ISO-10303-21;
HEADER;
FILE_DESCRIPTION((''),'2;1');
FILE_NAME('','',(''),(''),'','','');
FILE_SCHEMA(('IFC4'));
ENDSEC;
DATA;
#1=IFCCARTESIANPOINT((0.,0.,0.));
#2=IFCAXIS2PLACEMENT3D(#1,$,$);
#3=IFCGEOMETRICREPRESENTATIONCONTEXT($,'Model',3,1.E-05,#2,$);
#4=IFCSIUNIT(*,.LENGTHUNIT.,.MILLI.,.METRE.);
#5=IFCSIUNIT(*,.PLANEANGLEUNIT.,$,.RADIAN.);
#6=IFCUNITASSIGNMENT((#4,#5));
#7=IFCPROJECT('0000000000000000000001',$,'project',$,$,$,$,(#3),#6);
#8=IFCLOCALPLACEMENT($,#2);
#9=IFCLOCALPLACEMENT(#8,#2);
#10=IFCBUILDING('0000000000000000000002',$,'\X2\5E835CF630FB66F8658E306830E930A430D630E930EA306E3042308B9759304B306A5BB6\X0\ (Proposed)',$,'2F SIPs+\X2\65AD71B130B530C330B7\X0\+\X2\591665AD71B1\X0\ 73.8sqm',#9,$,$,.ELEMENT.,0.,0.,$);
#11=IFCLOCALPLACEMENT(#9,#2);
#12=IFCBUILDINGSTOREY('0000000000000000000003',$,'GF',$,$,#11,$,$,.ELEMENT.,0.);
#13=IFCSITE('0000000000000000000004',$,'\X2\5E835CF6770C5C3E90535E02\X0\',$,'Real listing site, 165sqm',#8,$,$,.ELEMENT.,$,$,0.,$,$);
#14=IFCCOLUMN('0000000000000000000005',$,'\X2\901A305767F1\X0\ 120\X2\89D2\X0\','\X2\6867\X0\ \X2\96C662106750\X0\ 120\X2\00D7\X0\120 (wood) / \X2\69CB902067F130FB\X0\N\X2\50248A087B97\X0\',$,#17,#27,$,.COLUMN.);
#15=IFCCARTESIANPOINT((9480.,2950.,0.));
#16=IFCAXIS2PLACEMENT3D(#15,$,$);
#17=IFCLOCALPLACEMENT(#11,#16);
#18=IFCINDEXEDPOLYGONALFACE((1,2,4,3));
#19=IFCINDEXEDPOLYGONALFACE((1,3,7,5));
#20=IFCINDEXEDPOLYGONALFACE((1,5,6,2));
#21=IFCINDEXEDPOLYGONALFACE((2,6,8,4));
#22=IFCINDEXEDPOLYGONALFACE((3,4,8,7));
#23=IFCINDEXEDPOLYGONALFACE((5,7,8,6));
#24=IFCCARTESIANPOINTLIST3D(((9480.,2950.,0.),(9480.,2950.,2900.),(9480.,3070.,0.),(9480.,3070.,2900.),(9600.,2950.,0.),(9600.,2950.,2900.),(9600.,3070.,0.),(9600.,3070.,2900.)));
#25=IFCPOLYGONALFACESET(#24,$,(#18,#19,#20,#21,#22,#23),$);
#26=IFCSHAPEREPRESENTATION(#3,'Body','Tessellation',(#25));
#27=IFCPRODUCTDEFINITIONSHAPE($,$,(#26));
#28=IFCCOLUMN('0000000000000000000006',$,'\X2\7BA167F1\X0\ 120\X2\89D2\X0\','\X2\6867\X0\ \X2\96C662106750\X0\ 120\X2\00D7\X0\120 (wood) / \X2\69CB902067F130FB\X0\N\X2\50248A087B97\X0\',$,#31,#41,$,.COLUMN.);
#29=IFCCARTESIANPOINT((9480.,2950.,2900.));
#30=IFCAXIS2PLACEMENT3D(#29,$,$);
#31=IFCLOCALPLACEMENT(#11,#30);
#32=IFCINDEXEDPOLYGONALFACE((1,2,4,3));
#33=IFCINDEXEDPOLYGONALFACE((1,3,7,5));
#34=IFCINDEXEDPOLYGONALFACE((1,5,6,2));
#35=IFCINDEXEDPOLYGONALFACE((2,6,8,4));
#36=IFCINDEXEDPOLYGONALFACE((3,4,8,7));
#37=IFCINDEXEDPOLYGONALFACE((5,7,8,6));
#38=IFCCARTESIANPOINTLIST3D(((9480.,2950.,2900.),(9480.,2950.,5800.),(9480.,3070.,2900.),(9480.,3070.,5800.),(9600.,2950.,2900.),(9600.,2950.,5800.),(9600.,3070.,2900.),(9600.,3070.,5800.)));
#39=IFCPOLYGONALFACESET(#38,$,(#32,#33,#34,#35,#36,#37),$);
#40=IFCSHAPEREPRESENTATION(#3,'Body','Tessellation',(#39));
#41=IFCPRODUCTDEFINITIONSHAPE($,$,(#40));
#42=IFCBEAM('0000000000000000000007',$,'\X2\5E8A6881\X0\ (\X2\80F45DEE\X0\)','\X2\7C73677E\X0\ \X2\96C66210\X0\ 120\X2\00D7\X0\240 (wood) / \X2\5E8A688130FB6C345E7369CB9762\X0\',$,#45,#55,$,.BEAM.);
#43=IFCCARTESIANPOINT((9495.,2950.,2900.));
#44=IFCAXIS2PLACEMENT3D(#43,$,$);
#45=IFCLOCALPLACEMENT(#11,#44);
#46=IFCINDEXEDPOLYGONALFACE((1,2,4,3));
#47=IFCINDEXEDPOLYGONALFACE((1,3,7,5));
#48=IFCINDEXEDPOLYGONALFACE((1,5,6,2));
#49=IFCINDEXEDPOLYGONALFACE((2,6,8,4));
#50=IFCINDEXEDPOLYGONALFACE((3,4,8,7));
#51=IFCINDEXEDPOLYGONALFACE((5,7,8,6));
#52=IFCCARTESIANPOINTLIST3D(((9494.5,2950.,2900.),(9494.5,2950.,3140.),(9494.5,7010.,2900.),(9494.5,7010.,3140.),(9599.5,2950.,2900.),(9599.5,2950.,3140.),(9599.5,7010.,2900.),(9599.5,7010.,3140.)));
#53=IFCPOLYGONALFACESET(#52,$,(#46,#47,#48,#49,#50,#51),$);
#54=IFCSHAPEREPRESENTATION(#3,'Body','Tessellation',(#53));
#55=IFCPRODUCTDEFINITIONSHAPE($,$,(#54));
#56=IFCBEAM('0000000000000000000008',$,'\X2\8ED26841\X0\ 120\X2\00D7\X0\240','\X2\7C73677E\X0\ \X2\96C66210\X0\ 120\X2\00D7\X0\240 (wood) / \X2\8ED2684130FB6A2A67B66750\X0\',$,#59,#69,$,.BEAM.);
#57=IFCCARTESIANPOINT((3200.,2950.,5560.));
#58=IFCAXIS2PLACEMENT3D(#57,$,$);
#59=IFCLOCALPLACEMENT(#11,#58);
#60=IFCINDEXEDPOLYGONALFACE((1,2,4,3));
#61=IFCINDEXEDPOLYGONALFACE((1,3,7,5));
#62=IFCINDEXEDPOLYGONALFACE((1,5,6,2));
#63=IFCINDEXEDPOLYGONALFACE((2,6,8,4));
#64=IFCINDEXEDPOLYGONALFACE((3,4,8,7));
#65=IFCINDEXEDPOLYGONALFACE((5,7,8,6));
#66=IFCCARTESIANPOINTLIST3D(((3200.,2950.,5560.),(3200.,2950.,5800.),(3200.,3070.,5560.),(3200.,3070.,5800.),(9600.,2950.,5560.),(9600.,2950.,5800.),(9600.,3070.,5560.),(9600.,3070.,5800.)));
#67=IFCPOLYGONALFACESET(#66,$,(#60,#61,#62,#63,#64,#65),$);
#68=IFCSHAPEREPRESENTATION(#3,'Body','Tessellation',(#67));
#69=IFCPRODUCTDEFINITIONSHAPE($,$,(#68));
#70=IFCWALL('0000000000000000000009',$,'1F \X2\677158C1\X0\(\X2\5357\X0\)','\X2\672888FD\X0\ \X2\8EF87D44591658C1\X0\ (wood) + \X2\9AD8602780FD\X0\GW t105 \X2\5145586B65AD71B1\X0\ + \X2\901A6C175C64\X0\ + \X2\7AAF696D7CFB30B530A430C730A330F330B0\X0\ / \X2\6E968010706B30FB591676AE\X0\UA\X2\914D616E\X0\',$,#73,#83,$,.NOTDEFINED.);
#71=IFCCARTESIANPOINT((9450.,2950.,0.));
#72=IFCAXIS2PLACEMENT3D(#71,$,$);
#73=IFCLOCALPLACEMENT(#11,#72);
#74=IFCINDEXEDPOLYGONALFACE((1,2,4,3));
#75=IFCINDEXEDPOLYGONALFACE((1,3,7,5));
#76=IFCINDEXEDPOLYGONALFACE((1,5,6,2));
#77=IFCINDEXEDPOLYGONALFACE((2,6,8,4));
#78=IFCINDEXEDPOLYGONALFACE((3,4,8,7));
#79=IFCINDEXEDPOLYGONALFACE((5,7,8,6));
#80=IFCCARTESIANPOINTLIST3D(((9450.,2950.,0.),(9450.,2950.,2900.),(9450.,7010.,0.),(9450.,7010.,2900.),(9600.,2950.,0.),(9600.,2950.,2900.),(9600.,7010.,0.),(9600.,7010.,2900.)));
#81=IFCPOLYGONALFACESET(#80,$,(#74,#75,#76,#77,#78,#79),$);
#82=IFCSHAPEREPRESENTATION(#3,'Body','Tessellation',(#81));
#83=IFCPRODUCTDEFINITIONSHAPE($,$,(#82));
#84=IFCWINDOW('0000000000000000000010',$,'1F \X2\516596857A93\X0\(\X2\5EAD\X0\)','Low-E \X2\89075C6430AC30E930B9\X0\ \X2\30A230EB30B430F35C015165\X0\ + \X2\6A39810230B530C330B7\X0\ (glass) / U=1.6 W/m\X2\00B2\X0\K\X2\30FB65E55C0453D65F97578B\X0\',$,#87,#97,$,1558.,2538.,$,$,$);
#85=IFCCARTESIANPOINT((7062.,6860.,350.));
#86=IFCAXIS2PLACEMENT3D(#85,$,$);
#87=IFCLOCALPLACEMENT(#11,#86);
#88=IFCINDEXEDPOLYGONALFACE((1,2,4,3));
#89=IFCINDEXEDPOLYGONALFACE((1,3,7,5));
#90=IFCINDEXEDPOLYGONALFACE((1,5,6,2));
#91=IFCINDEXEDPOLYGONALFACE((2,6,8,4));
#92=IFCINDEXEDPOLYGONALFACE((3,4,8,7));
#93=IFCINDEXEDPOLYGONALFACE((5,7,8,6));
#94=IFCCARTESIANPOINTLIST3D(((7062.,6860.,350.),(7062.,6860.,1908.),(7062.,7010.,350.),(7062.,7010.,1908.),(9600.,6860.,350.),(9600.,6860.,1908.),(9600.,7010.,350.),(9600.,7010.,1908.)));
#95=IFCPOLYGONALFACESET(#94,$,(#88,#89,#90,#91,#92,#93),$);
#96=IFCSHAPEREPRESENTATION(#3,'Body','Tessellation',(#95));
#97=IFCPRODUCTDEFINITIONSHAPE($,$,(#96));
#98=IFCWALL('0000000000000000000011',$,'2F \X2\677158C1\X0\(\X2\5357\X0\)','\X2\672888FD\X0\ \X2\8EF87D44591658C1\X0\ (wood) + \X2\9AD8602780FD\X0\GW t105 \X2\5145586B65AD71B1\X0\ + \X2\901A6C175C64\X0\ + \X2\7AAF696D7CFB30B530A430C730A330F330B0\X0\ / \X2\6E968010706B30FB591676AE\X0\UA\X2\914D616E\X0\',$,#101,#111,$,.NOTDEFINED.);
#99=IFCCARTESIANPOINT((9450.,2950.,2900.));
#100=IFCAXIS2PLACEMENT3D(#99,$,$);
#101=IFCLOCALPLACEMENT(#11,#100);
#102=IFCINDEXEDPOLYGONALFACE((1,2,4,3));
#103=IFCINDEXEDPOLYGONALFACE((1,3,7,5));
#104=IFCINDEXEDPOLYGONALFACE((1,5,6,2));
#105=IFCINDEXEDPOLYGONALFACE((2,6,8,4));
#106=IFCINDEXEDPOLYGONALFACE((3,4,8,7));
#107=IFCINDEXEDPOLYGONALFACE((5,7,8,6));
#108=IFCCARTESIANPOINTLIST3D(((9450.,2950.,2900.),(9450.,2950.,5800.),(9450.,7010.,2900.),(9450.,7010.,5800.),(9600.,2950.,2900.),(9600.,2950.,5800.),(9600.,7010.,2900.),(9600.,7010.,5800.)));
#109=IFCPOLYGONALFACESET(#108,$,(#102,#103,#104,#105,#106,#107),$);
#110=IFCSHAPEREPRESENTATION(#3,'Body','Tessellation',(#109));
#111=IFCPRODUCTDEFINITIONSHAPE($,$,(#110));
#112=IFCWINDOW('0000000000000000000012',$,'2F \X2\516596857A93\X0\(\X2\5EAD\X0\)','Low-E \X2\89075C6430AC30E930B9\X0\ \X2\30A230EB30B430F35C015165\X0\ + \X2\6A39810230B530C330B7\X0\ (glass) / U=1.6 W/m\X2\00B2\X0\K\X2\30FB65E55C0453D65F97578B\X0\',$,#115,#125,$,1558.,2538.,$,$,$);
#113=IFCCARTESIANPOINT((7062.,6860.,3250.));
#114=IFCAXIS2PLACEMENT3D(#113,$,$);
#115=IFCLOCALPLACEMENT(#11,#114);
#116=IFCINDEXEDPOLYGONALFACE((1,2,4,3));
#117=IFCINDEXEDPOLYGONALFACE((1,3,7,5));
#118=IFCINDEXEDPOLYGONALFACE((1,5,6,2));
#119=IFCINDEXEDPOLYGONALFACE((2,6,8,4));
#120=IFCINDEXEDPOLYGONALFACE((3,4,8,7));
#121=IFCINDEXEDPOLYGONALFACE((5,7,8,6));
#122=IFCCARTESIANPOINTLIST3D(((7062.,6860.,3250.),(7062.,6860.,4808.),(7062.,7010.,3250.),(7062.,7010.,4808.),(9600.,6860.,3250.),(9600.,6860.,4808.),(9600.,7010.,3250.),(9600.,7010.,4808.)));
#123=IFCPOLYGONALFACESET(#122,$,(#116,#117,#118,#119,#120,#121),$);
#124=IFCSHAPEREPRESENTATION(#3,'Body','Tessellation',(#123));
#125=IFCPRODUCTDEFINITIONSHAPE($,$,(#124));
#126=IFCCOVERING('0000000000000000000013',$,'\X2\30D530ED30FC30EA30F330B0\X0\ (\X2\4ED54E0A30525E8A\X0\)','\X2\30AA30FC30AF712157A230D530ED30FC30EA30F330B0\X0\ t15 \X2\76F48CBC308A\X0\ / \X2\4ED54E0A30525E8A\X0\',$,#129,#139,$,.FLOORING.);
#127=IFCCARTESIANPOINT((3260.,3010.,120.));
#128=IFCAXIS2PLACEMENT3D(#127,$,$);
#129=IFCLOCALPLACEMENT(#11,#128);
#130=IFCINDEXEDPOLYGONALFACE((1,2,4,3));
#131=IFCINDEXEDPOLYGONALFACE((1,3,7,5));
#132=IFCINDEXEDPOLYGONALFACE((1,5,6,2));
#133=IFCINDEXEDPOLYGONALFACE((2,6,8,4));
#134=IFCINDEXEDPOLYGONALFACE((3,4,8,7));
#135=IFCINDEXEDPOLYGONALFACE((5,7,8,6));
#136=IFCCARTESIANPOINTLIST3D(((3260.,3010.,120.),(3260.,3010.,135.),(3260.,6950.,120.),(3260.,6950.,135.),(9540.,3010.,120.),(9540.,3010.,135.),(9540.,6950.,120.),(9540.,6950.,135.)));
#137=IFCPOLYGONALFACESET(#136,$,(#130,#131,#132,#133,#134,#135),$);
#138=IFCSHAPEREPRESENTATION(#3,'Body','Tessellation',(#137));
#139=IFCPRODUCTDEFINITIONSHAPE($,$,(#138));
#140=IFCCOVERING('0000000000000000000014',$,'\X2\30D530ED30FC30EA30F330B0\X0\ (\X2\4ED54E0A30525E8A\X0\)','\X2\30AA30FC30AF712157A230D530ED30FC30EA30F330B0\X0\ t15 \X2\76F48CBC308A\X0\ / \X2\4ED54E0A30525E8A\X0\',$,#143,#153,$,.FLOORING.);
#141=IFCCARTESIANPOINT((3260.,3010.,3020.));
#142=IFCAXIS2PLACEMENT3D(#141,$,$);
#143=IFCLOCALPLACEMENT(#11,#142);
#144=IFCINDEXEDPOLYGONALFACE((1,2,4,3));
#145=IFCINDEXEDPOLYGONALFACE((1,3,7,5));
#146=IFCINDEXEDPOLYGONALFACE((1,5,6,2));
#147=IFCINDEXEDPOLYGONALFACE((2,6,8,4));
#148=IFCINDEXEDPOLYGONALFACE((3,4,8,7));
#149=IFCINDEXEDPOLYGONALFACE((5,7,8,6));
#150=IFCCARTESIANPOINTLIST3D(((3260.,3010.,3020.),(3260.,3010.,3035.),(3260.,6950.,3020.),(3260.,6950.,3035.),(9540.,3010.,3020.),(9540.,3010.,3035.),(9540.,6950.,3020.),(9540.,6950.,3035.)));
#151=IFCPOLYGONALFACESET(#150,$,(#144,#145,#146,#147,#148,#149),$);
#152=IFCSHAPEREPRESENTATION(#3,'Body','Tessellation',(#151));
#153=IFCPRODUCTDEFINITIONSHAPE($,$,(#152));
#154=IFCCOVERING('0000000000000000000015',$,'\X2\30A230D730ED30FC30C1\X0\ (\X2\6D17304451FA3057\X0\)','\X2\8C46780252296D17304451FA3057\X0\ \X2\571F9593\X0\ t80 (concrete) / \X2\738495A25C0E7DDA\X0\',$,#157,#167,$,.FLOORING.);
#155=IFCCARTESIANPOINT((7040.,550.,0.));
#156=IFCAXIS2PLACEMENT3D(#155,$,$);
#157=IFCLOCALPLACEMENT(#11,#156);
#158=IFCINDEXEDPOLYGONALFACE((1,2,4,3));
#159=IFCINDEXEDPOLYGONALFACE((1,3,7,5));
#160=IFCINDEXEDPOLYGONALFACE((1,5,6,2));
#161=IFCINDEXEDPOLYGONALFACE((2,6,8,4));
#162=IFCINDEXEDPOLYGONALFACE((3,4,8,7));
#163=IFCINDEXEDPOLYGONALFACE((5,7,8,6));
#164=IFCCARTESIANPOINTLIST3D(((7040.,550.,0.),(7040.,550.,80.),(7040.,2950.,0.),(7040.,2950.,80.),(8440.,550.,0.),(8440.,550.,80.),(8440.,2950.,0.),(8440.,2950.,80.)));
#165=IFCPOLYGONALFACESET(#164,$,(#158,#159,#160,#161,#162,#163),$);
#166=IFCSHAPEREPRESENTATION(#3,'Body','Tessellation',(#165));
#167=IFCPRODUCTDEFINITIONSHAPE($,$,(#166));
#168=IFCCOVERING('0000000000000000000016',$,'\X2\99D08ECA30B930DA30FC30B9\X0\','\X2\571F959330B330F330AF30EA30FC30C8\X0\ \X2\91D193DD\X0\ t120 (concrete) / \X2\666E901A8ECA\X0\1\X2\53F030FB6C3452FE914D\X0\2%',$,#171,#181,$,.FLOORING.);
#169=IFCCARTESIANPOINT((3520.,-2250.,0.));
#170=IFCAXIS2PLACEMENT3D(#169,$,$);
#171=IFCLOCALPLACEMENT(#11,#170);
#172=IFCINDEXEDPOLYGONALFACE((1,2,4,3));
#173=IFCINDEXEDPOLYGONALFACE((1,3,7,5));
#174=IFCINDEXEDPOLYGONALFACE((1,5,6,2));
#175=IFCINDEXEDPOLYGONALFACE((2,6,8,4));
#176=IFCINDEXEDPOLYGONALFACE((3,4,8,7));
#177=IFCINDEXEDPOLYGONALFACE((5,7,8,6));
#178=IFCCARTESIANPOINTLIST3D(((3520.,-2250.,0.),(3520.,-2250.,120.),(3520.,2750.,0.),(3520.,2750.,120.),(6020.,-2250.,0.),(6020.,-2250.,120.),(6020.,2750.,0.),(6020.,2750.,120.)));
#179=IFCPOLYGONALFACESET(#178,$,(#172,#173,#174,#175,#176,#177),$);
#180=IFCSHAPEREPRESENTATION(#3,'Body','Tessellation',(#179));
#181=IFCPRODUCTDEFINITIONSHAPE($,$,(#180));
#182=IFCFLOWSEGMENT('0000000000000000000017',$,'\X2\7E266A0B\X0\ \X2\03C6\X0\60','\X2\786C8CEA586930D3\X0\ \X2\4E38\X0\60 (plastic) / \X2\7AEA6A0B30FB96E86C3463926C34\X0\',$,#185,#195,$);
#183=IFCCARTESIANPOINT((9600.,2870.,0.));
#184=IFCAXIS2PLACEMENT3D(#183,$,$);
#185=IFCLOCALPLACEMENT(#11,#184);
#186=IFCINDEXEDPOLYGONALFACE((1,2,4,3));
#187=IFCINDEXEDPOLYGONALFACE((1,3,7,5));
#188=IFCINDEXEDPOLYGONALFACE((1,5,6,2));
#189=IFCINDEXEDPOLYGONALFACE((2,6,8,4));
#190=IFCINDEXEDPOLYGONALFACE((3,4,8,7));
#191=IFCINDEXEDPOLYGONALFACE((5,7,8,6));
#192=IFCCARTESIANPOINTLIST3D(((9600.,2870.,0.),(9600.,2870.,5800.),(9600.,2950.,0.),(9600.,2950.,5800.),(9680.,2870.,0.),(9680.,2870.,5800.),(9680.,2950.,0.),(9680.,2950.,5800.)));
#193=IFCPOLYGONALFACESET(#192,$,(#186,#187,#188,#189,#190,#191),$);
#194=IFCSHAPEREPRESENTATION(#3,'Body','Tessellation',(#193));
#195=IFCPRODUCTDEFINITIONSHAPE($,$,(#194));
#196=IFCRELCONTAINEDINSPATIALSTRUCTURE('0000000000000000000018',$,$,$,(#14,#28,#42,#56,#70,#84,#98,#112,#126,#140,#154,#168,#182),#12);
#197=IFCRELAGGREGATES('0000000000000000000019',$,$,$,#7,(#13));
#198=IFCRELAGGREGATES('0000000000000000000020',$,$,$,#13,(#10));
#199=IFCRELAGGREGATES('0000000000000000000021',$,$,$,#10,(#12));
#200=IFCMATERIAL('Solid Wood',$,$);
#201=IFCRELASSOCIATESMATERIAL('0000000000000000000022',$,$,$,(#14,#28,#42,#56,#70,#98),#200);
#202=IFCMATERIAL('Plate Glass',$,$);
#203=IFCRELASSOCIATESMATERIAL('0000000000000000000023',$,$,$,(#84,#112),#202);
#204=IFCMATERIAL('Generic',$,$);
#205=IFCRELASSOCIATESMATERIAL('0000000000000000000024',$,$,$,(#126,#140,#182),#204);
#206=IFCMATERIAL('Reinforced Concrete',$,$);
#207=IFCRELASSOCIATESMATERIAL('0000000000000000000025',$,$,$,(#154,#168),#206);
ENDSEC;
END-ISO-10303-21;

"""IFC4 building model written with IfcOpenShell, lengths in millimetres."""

from ifc_helpers import new_model, si_unit, frame, frame_2d, origin, place, context, project, spatial, rectangle, extrude, material, element, fill, save


model = new_model("IFC4")

# Units and contexts
model_context = context("Model", 3, precision=1e-05, world=origin())
ifc_project = project(units=[si_unit("LENGTHUNIT", "METRE", prefix="MILLI"), si_unit("PLANEANGLEUNIT", "RADIAN")], contexts=[model_context])

# Site, building, storey
site_placement = place(None, origin())
site = spatial("IfcSite", under=ifc_project, at=site_placement, Name="広島県尾道市", ObjectType="Real listing site, 165sqm", CompositionType="ELEMENT", RefElevation=0.0)
building_placement = place(site_placement, origin())
building = spatial("IfcBuilding", under=site, at=building_placement, Name="広島・書斎とライブラリのある静かな家 (Proposed)", ObjectType="2F SIPs+断熱サッシ+外断熱 73.8sqm", CompositionType="ELEMENT", ElevationOfRefHeight=0.0, ElevationOfTerrain=0.0)
storey_placement = place(building_placement, origin())
storey = spatial("IfcBuildingStorey", under=building, at=storey_placement, Name="GF", CompositionType="ELEMENT", Elevation=0.0)

# Columns
ifc_material_1 = material(Name="Solid Wood")
column_1_placement = place(storey_placement, frame((9480.0, 2950.0, 0.0)))
element("IfcColumn", 1, at=column_1_placement, inside=storey, material=ifc_material_1, Name="通し柱 120角", Description="桧 集成材 120×120 (wood) / 構造柱・N値計算", PredefinedType="COLUMN", context=model_context, shape_type="SweptSolid", body=[
    extrude(rectangle(XDim=120.0, YDim=120.0, at=frame_2d((60.0, 60.0))), frame((9480.0, 2950.0, 0.0)), (0.0, 0.0, 1.0), 2900.0),
])
column_2_placement = place(storey_placement, frame((9480.0, 2950.0, 2900.0)))
element("IfcColumn", 2, at=column_2_placement, inside=storey, material=ifc_material_1, Name="管柱 120角", Description="桧 集成材 120×120 (wood) / 構造柱・N値計算", PredefinedType="COLUMN", context=model_context, shape_type="SweptSolid", body=[
    extrude(rectangle(XDim=120.0, YDim=120.0, at=frame_2d((60.0, 60.0))), frame((9480.0, 2950.0, 2900.0)), (0.0, 0.0, 1.0), 2900.0),
])

# Beams
beam_1_placement = place(storey_placement, frame((9495.0, 2950.0, 2900.0)))
element("IfcBeam", 3, at=beam_1_placement, inside=storey, material=ifc_material_1, Name="床梁 (胴差)", Description="米松 集成 120×240 (wood) / 床梁・水平構面", PredefinedType="BEAM", context=model_context, shape_type="SweptSolid", body=[
    extrude(rectangle(XDim=105.0, YDim=4060.0, at=frame_2d((52.0, 2030.0))), frame((9495.0, 2950.0, 2900.0)), (0.0, 0.0, 1.0), 240.0),
])
beam_2_placement = place(storey_placement, frame((3200.0, 2950.0, 5560.0)))
element("IfcBeam", 4, at=beam_2_placement, inside=storey, material=ifc_material_1, Name="軒桁 120×240", Description="米松 集成 120×240 (wood) / 軒桁・横架材", PredefinedType="BEAM", context=model_context, shape_type="SweptSolid", body=[
    extrude(rectangle(XDim=6400.0, YDim=120.0, at=frame_2d((3200.0, 60.0))), frame((3200.0, 2950.0, 5560.0)), (0.0, 0.0, 1.0), 240.0),
])

# Wall, opening, window
wall_1_placement = place(storey_placement, frame((9450.0, 2950.0, 0.0)))
wall_1 = element("IfcWall", 5, at=wall_1_placement, inside=storey, material=ifc_material_1, Name="1F 東壁(南)", Description="木製 軸組外壁 (wood) + 高性能GW t105 充填断熱 + 通気層 + 窯業系サイディング / 準耐火・外皮UA配慮", PredefinedType="NOTDEFINED", context=model_context, shape_type="SweptSolid", body=[
    extrude(rectangle(XDim=150.0, YDim=4060.0, at=frame_2d((75.0, 2030.0))), frame((9450.0, 2950.0, 0.0)), (0.0, 0.0, 1.0), 2900.0),
])
opening_1_placement = place(storey_placement, frame((7062.0, 6860.0, 350.0)))
opening_1 = element("IfcOpeningElement", 6, at=opening_1_placement, cuts=wall_1, PredefinedType="NOTDEFINED", context=model_context, shape_type="SweptSolid", body=[
    extrude(rectangle(XDim=2538.0, YDim=150.0, at=frame_2d((1269.0, 75.0))), frame((7062.0, 6860.0, 350.0)), (0.0, 0.0, 1.0), 1558.0),
])
ifc_material_2 = material(Name="Plate Glass")
window_1_placement = place(storey_placement, frame((7062.0, 6860.0, 350.0)))
window_1 = element("IfcWindow", 7, at=window_1_placement, inside=storey, material=ifc_material_2, Name="1F 入隅窓(庭)", Description="Low-E 複層ガラス アルゴン封入 + 樹脂サッシ (glass) / U=1.6 W/m²K・日射取得型", OverallHeight=1558.0, OverallWidth=2538.0, context=model_context, shape_type="SweptSolid", body=[
    extrude(rectangle(XDim=2538.0, YDim=150.0, at=frame_2d((1269.0, 75.0))), frame((7062.0, 6860.0, 350.0)), (0.0, 0.0, 1.0), 1558.0),
])
fill(opening_1, window_1)

# Wall, opening, window
wall_2_placement = place(storey_placement, frame((9450.0, 2950.0, 2900.0)))
wall_2 = element("IfcWall", 8, at=wall_2_placement, inside=storey, material=ifc_material_1, Name="2F 東壁(南)", Description="木製 軸組外壁 (wood) + 高性能GW t105 充填断熱 + 通気層 + 窯業系サイディング / 準耐火・外皮UA配慮", PredefinedType="NOTDEFINED", context=model_context, shape_type="SweptSolid", body=[
    extrude(rectangle(XDim=150.0, YDim=4060.0, at=frame_2d((75.0, 2030.0))), frame((9450.0, 2950.0, 2900.0)), (0.0, 0.0, 1.0), 2900.0),
])
opening_2_placement = place(storey_placement, frame((7062.0, 6860.0, 3250.0)))
opening_2 = element("IfcOpeningElement", 9, at=opening_2_placement, cuts=wall_2, PredefinedType="NOTDEFINED", context=model_context, shape_type="SweptSolid", body=[
    extrude(rectangle(XDim=2538.0, YDim=150.0, at=frame_2d((1269.0, 75.0))), frame((7062.0, 6860.0, 3250.0)), (0.0, 0.0, 1.0), 1558.0),
])
window_2_placement = place(storey_placement, frame((7062.0, 6860.0, 3250.0)))
window_2 = element("IfcWindow", 10, at=window_2_placement, inside=storey, material=ifc_material_2, Name="2F 入隅窓(庭)", Description="Low-E 複層ガラス アルゴン封入 + 樹脂サッシ (glass) / U=1.6 W/m²K・日射取得型", OverallHeight=1558.0, OverallWidth=2538.0, context=model_context, shape_type="SweptSolid", body=[
    extrude(rectangle(XDim=2538.0, YDim=150.0, at=frame_2d((1269.0, 75.0))), frame((7062.0, 6860.0, 3250.0)), (0.0, 0.0, 1.0), 1558.0),
])
fill(opening_2, window_2)

# Coverings
ifc_material_3 = material(Name="Generic")
covering_1_placement = place(storey_placement, frame((3260.0, 3010.0, 120.0)))
element("IfcCovering", 11, at=covering_1_placement, inside=storey, material=ifc_material_3, Name="フローリング (仕上げ床)", Description="オーク無垢フローリング t15 直貼り / 仕上げ床", PredefinedType="FLOORING", context=model_context, shape_type="SweptSolid", body=[
    extrude(rectangle(XDim=6280.0, YDim=3940.0, at=frame_2d((3140.0, 1970.0))), frame((3260.0, 3010.0, 120.0)), (0.0, 0.0, 1.0), 15.0),
])
covering_2_placement = place(storey_placement, frame((3260.0, 3010.0, 3020.0)))
element("IfcCovering", 12, at=covering_2_placement, inside=storey, material=ifc_material_3, Name="フローリング (仕上げ床)", Description="オーク無垢フローリング t15 直貼り / 仕上げ床", PredefinedType="FLOORING", context=model_context, shape_type="SweptSolid", body=[
    extrude(rectangle(XDim=6280.0, YDim=3940.0, at=frame_2d((3140.0, 1970.0))), frame((3260.0, 3010.0, 3020.0)), (0.0, 0.0, 1.0), 15.0),
])
ifc_material_4 = material(Name="Reinforced Concrete")
covering_3_placement = place(storey_placement, frame((7040.0, 550.0, 0.0)))
element("IfcCovering", 13, at=covering_3_placement, inside=storey, material=ifc_material_4, Name="アプローチ (洗い出し)", Description="豆砂利洗い出し 土間 t80 (concrete) / 玄関導線", PredefinedType="FLOORING", context=model_context, shape_type="SweptSolid", body=[
    extrude(rectangle(XDim=1400.0, YDim=2400.0, at=frame_2d((700.0, 1200.0))), frame((7040.0, 550.0, 0.0)), (0.0, 0.0, 1.0), 80.0),
])
covering_4_placement = place(storey_placement, frame((3520.0, -2250.0, 0.0)))
element("IfcCovering", 14, at=covering_4_placement, inside=storey, material=ifc_material_4, Name="駐車スペース", Description="土間コンクリート 金鏝 t120 (concrete) / 普通車1台・水勾配2%", PredefinedType="FLOORING", context=model_context, shape_type="SweptSolid", body=[
    extrude(rectangle(XDim=2500.0, YDim=5000.0, at=frame_2d((1250.0, 2500.0))), frame((3520.0, -2250.0, 0.0)), (0.0, 0.0, 1.0), 120.0),
])

# Flow segment
flow_segment_placement = place(storey_placement, frame((9600.0, 2870.0, 0.0)))
element("IfcFlowSegment", 15, at=flow_segment_placement, inside=storey, material=ifc_material_3, Name="縦樋 φ60", Description="硬質塩ビ 丸60 (plastic) / 竪樋・雨水排水", context=model_context, shape_type="SweptSolid", body=[
    extrude(rectangle(XDim=80.0, YDim=80.0, at=frame_2d((40.0, 40.0))), frame((9600.0, 2870.0, 0.0)), (0.0, 0.0, 1.0), 5800.0),
])

save(model, "model.ifc")
